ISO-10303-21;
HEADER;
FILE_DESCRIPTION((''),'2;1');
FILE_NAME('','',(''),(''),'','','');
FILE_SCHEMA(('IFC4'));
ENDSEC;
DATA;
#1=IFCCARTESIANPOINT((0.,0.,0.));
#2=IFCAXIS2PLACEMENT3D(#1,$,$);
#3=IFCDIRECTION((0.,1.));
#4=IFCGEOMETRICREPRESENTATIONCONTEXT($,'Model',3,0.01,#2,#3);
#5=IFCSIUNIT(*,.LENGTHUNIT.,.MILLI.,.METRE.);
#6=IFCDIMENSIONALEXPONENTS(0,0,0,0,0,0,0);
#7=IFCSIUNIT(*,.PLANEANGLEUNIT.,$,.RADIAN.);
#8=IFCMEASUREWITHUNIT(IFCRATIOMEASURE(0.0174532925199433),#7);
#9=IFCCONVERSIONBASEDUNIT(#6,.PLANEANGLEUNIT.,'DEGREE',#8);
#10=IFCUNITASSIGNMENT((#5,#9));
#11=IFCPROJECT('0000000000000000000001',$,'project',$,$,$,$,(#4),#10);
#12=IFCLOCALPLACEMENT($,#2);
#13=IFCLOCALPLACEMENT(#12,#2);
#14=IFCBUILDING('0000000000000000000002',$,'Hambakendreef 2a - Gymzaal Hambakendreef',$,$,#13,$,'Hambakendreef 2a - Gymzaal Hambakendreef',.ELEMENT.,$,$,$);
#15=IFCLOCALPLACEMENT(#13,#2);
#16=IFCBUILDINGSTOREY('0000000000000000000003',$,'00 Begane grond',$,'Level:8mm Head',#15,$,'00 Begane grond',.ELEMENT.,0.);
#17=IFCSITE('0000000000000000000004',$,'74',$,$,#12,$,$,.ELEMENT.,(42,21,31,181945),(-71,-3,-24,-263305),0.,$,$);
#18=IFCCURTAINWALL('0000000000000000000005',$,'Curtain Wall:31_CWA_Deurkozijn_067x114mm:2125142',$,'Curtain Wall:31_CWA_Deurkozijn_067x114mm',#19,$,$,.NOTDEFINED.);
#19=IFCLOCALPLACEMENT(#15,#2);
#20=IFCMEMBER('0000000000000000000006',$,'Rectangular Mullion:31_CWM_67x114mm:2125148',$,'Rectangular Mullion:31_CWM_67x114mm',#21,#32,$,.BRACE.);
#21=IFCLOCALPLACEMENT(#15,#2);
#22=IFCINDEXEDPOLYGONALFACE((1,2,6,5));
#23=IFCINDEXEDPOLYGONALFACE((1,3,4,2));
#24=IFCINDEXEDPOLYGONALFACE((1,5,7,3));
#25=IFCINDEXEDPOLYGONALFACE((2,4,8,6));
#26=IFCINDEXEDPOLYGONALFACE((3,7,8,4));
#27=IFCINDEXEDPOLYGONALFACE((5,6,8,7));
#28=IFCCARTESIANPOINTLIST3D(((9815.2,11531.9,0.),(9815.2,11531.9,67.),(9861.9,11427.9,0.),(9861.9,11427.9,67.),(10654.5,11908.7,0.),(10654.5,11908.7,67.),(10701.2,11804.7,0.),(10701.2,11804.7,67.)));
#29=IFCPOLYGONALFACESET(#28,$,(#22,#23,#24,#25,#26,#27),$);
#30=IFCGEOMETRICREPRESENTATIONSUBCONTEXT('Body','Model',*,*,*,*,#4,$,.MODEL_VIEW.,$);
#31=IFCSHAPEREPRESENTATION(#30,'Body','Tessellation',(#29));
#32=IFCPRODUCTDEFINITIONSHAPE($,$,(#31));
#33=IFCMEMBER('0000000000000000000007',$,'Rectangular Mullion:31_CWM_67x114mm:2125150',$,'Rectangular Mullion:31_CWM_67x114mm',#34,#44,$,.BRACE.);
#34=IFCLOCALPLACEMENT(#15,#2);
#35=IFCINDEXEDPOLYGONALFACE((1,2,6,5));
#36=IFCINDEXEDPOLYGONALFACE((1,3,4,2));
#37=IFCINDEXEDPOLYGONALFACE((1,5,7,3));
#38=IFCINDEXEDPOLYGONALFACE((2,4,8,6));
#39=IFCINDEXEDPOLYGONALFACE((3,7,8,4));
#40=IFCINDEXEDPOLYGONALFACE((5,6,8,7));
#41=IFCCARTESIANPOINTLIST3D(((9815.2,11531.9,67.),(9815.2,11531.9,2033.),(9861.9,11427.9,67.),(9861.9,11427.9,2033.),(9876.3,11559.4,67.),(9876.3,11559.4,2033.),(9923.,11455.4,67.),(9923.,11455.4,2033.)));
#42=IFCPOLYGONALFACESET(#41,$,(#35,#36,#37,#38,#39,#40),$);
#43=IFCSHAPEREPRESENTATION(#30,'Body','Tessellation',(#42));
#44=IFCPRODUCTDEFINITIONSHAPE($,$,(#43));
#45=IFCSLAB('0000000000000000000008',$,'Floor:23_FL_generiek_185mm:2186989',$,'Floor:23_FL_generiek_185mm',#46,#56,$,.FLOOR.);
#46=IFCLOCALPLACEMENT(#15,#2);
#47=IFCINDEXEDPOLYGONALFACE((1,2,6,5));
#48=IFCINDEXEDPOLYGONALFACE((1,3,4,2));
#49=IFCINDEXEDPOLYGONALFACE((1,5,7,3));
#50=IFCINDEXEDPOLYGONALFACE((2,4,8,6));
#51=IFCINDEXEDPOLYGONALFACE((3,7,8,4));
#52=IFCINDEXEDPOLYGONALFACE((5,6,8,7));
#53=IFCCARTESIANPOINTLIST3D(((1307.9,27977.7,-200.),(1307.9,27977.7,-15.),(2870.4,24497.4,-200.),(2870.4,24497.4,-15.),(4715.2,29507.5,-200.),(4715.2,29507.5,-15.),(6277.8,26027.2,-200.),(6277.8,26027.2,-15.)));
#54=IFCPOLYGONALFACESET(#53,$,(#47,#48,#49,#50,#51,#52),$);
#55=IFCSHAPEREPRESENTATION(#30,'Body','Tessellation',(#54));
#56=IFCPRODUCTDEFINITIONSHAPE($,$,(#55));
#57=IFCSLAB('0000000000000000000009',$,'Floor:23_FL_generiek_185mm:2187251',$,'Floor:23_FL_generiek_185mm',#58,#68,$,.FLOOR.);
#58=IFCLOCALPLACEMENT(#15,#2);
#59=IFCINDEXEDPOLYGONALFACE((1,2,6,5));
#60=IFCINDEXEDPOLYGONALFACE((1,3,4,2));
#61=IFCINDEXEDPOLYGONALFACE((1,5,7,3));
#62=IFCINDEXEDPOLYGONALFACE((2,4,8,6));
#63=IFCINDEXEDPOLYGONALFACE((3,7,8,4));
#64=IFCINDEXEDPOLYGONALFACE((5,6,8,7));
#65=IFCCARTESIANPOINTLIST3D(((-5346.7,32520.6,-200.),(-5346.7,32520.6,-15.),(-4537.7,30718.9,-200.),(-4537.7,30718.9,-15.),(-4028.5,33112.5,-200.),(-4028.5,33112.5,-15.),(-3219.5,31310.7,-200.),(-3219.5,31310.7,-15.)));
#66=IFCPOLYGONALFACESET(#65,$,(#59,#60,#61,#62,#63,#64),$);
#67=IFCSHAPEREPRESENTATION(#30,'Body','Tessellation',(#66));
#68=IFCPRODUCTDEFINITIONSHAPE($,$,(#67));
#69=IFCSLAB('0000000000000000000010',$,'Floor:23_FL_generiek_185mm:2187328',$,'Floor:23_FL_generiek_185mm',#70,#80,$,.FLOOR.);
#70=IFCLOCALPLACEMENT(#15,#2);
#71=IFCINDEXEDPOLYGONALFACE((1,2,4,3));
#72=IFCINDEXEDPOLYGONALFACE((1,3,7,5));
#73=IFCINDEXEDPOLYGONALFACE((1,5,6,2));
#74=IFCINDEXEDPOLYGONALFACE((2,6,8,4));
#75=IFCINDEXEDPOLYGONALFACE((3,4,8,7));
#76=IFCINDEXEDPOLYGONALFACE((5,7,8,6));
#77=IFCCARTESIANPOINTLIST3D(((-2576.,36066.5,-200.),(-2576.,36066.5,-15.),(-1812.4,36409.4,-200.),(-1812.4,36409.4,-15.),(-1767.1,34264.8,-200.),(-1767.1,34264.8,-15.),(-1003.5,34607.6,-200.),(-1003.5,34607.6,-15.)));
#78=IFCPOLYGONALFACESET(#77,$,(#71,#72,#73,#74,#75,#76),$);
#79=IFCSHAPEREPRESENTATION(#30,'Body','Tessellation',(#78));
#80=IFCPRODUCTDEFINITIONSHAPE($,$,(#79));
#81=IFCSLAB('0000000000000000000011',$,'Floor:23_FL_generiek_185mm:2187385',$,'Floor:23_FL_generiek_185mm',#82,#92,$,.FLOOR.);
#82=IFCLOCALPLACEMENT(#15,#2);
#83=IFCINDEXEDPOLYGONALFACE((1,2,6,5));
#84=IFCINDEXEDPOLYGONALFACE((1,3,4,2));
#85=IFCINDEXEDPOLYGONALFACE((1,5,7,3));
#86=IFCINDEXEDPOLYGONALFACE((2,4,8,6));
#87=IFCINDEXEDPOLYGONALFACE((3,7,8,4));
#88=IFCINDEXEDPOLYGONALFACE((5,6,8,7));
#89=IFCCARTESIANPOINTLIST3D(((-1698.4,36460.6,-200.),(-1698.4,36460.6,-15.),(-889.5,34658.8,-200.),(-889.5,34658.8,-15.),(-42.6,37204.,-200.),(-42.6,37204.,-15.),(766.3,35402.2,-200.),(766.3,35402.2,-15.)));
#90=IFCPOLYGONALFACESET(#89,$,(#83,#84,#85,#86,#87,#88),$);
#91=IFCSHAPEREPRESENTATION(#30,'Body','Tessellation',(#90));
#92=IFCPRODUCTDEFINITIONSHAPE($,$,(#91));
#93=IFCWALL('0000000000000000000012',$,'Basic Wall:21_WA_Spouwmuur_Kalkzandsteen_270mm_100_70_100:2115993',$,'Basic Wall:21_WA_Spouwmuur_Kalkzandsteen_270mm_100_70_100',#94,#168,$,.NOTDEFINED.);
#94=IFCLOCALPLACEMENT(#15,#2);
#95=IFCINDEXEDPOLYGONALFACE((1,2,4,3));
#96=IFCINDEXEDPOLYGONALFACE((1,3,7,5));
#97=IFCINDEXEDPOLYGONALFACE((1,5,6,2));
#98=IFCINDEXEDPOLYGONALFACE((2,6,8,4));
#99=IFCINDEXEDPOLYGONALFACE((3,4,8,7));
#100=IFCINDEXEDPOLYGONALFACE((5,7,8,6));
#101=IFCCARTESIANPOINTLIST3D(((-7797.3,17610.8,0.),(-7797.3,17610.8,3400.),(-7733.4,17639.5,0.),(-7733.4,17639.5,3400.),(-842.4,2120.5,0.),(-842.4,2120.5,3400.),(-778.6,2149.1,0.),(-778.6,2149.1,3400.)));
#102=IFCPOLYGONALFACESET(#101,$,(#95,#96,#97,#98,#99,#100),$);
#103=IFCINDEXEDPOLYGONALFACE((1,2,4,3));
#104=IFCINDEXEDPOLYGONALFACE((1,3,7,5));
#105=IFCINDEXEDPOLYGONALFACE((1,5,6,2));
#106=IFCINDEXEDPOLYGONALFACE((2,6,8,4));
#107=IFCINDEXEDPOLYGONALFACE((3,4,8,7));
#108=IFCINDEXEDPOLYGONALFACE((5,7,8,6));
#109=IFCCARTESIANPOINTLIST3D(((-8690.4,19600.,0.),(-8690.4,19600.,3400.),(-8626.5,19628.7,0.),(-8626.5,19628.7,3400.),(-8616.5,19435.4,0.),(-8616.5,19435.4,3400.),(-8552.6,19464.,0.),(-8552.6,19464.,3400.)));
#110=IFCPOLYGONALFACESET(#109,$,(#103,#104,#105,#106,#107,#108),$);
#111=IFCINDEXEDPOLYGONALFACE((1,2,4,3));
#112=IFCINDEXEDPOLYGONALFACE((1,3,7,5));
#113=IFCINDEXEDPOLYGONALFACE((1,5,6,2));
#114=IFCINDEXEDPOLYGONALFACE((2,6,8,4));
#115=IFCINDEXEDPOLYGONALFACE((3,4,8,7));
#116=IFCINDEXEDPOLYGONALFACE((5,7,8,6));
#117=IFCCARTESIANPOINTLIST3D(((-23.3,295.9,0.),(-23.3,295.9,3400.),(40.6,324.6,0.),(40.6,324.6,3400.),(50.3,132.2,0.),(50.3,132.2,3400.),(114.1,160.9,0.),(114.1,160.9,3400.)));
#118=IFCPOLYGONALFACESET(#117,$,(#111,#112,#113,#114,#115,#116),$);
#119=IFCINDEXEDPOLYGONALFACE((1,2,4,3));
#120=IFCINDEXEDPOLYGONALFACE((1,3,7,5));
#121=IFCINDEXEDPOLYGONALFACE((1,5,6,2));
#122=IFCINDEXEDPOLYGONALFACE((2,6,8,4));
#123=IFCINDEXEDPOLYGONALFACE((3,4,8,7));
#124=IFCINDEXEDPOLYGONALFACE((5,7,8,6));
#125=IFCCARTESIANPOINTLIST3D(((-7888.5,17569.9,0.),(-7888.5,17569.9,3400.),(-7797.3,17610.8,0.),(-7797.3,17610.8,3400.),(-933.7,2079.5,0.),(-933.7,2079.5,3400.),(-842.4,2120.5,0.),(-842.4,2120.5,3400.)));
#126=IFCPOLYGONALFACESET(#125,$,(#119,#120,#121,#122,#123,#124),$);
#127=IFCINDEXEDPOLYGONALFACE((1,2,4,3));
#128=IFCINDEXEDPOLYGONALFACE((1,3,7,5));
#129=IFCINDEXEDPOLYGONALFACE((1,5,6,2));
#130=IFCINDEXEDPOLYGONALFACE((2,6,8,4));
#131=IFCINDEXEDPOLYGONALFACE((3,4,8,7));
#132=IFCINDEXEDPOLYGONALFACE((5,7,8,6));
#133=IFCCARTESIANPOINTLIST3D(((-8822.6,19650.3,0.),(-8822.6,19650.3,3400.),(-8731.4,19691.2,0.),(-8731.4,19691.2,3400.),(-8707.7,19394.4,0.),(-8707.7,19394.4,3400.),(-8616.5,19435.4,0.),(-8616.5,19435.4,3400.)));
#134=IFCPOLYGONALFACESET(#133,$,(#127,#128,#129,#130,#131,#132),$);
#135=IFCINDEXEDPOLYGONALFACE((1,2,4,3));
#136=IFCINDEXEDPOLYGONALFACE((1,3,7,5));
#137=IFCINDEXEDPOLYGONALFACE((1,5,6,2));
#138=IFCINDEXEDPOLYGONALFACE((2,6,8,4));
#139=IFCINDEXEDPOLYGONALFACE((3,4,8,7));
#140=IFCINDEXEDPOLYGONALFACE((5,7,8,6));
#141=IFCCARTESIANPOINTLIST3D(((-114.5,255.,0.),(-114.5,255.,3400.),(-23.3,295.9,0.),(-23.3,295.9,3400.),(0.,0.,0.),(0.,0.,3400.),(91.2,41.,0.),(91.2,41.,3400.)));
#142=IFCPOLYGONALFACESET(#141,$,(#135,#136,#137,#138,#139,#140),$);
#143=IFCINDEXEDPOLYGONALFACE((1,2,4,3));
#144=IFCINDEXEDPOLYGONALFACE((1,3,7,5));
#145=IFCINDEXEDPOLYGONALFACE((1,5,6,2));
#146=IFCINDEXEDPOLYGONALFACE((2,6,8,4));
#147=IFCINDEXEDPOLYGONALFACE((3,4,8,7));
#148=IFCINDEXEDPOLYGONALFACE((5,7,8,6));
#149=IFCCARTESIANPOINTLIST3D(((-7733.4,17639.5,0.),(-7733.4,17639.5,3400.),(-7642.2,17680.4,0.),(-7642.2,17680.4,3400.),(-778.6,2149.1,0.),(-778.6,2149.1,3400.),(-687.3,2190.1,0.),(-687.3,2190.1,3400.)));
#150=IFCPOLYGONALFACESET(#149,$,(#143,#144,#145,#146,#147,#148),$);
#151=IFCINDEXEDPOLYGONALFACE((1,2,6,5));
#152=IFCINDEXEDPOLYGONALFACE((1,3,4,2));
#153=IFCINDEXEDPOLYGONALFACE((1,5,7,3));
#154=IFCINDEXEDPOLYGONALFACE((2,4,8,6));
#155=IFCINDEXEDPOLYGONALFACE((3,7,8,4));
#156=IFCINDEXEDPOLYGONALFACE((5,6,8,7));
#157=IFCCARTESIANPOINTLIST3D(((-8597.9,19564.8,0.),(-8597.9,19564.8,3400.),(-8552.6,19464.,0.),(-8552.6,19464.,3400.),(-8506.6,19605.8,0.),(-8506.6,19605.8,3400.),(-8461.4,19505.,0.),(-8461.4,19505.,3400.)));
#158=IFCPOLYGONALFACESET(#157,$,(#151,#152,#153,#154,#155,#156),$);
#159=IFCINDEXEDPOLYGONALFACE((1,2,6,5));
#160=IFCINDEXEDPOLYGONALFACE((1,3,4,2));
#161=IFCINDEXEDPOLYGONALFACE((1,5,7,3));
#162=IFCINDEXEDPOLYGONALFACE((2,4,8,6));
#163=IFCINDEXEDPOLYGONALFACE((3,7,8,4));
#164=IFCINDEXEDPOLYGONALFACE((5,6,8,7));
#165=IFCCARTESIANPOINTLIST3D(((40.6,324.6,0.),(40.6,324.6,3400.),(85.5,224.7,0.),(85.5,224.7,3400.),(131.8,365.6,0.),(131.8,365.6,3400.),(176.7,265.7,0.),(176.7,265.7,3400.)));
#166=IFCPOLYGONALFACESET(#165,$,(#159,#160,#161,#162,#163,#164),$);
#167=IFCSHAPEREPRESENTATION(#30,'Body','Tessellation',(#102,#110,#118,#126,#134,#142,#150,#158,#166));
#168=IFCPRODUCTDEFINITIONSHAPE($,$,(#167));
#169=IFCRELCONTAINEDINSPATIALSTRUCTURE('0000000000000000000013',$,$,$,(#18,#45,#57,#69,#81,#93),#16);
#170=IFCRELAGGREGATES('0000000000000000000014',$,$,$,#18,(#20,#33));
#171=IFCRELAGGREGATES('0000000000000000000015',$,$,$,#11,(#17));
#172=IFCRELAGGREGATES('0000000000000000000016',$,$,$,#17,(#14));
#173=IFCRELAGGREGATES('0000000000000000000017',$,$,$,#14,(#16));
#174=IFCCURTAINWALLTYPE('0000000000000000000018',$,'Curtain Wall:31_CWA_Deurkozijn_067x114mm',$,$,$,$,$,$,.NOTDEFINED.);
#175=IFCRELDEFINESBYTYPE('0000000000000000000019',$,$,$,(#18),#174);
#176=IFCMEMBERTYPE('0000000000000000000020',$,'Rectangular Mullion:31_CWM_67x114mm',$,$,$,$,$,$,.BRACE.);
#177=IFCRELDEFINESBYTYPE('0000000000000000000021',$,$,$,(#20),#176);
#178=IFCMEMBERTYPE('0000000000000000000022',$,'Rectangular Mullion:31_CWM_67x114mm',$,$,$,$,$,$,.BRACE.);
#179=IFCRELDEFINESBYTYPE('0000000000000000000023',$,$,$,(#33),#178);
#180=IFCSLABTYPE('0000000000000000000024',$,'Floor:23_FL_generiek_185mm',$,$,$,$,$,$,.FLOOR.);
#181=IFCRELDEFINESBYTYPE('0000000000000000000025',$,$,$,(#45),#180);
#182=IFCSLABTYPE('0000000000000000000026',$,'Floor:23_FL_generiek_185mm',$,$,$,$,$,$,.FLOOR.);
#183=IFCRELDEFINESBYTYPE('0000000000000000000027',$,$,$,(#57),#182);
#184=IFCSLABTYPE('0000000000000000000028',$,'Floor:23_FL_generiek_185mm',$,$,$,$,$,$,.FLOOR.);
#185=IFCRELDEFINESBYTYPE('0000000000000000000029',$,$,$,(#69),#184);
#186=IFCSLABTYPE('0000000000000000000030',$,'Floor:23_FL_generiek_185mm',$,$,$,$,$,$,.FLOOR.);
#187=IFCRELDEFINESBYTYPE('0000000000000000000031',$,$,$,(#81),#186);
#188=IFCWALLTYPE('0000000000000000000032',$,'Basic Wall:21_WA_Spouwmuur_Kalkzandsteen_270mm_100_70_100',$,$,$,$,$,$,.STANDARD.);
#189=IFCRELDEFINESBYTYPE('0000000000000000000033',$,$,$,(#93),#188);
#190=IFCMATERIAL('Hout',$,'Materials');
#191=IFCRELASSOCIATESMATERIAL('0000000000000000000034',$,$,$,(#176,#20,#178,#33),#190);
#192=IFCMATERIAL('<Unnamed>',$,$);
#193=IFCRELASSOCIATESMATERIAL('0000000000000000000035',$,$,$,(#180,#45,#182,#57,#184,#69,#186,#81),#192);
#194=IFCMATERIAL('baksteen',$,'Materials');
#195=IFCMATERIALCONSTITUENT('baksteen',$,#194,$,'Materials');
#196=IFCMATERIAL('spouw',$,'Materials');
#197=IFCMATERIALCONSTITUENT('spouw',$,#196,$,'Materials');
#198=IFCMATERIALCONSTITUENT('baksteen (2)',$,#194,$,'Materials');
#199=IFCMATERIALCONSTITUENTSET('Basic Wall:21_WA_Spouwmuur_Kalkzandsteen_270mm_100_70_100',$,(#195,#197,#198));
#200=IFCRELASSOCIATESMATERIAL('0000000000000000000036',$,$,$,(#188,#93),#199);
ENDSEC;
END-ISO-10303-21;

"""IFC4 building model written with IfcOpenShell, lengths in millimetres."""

from ifc_helpers import new_model, entity, si_unit, converted_unit, direction, frame, origin, place, context, subcontext, project, spatial, indexed_curve, outline, extrude, source, transform, mapped, material, constituent, constituent_set, type_object, type_shapes, element, aggregate, save


model = new_model("IFC4")

# Units and contexts
model_context = context("Model", 3, precision=0.01, world=origin(), true_north=direction((0.0, 1.0)))
body_context = subcontext(model_context, "Body", "Model", "MODEL_VIEW")
ifc_project = project(units=[si_unit("LENGTHUNIT", "METRE", prefix="MILLI"), converted_unit("PLANEANGLEUNIT", "DEGREE", entity("IfcRatioMeasure", 0.0174532925199433), si_unit("PLANEANGLEUNIT", "RADIAN"), dimensions=[0, 0, 0, 0, 0, 0, 0])], contexts=[model_context])

# Site, building, storey
site_placement = place(None, origin())
site = spatial("IfcSite", under=ifc_project, at=site_placement, Name="74", CompositionType="ELEMENT", RefLatitude=(42, 21, 31, 181945), RefLongitude=(-71, -3, -24, -263305), RefElevation=0.0)
building_placement = place(site_placement, origin())
building = spatial("IfcBuilding", under=site, at=building_placement, Name="Hambakendreef 2a - Gymzaal Hambakendreef", LongName="Hambakendreef 2a - Gymzaal Hambakendreef", CompositionType="ELEMENT")
storey_placement = place(building_placement, origin())
storey = spatial("IfcBuildingStorey", under=building, at=storey_placement, Name="00 Begane grond", ObjectType="Level:8mm Head", LongName="00 Begane grond", CompositionType="ELEMENT", Elevation=0.0)

# Shared definitions
ifc_material_1 = material(Name="<Unnamed>")

# Curtain wall, members
curtain_wall_type = type_object("IfcCurtainWallType", Name="Curtain Wall:31_CWA_Deurkozijn_067x114mm", PredefinedType="NOTDEFINED")
curtain_wall_placement = place(storey_placement, origin())
curtain_wall = element("IfcCurtainWall", 1, at=curtain_wall_placement, inside=storey, type_object=curtain_wall_type, Name="Curtain Wall:31_CWA_Deurkozijn_067x114mm:2125142", ObjectType="Curtain Wall:31_CWA_Deurkozijn_067x114mm", PredefinedType="NOTDEFINED")
ifc_material_2 = material(Name="Hout", Category="Materials")
member_type_1 = type_object("IfcMemberType", Name="Rectangular Mullion:31_CWM_67x114mm", PredefinedType="BRACE", material=ifc_material_2)
shared_shape_1 = source(origin(), body_context, "Body", "SweptSolid", [
    extrude(outline(indexed_curve([(-57.0, -33.5), (57.0, -33.5), (57.0, 33.5), (-57.0, 33.5), (-57.0, -33.5)], self_intersect=False)), frame((-33.5, 0.0, -920.0), z_axis=(0.0, 0.0, 1.0), x_axis=(0.0, -1.0, 0.0)), (0.0, 0.0, 1.0), 920.0),
])
type_shapes(member_type_1, [shared_shape_1])
member_1_placement = place(storey_placement, frame((9838.6, 11479.9, 0.0), z_axis=(-0.91227, -0.40959, 0.0), x_axis=(0.0, 0.0, -1.0)))
member_1 = element("IfcMember", 2, at=member_1_placement, type_object=member_type_1, material=ifc_material_2, Name="Rectangular Mullion:31_CWM_67x114mm:2125148", ObjectType="Rectangular Mullion:31_CWM_67x114mm", PredefinedType="BRACE", context=body_context, shape_type="MappedRepresentation", body=[
    mapped(shared_shape_1, transform((0.0, 0.0, 0.0), scale=1.0)),
])
member_type_2 = type_object("IfcMemberType", Name="Rectangular Mullion:31_CWM_67x114mm", PredefinedType="BRACE", material=ifc_material_2)
shared_shape_2 = source(origin(), body_context, "Body", "SweptSolid", [
    extrude(outline(indexed_curve([(-57.0, -33.5), (57.0, -33.5), (57.0, 33.5), (-57.0, 33.5), (-57.0, -33.5)], self_intersect=False)), frame((-33.5, 0.0, -1966.0), z_axis=(0.0, 0.0, 1.0), x_axis=(0.0, -1.0, 0.0)), (0.0, 0.0, 1.0), 1966.0),
])
type_shapes(member_type_2, [shared_shape_2])
member_2_placement = place(storey_placement, frame((9838.6, 11479.9, 2033.0), z_axis=(0.0, 0.0, 1.0), x_axis=(-0.91227, -0.40959, 0.0)))
member_2 = element("IfcMember", 3, at=member_2_placement, type_object=member_type_2, material=ifc_material_2, Name="Rectangular Mullion:31_CWM_67x114mm:2125150", ObjectType="Rectangular Mullion:31_CWM_67x114mm", PredefinedType="BRACE", context=body_context, shape_type="MappedRepresentation", body=[
    mapped(shared_shape_2, transform((0.0, 0.0, 0.0), scale=1.0)),
])
aggregate(curtain_wall, [member_1, member_2])

# Slabs
slab_type_1 = type_object("IfcSlabType", Name="Floor:23_FL_generiek_185mm", PredefinedType="FLOOR", material=ifc_material_1)
slab_1_placement = place(storey_placement, origin())
element("IfcSlab", 4, at=slab_1_placement, inside=storey, type_object=slab_type_1, material=ifc_material_1, Name="Floor:23_FL_generiek_185mm:2186989", ObjectType="Floor:23_FL_generiek_185mm", PredefinedType="FLOOR", context=body_context, shape_type="SweptSolid", body=[
    extrude(outline(indexed_curve([(-1907.5, -1867.5), (1907.5, -1867.5), (1907.5, 1867.5), (-1907.5, 1867.5), (-1907.5, -1867.5)], self_intersect=False)), frame((3792.8, 27002.4, -15.0), z_axis=(0.0, 0.0, -1.0), x_axis=(0.40959, -0.91227, 0.0)), (0.0, 0.0, 1.0), 185.0),
])
slab_type_2 = type_object("IfcSlabType", Name="Floor:23_FL_generiek_185mm", PredefinedType="FLOOR", material=ifc_material_1)
slab_2_placement = place(storey_placement, origin())
element("IfcSlab", 5, at=slab_2_placement, inside=storey, type_object=slab_type_2, material=ifc_material_1, Name="Floor:23_FL_generiek_185mm:2187251", ObjectType="Floor:23_FL_generiek_185mm", PredefinedType="FLOOR", context=body_context, shape_type="SweptSolid", body=[
    extrude(outline(indexed_curve([(-987.5, -722.5), (987.5, -722.5), (987.5, 722.5), (-987.5, 722.5), (-987.5, -722.5)], self_intersect=False)), frame((-4283.1, 31915.7, -15.0), z_axis=(0.0, 0.0, -1.0), x_axis=(0.40959, -0.91227, 0.0)), (0.0, 0.0, 1.0), 185.0),
])
slab_type_3 = type_object("IfcSlabType", Name="Floor:23_FL_generiek_185mm", PredefinedType="FLOOR", material=ifc_material_1)
slab_3_placement = place(storey_placement, origin())
element("IfcSlab", 6, at=slab_3_placement, inside=storey, type_object=slab_type_3, material=ifc_material_1, Name="Floor:23_FL_generiek_185mm:2187328", ObjectType="Floor:23_FL_generiek_185mm", PredefinedType="FLOOR", context=body_context, shape_type="SweptSolid", body=[
    extrude(outline(indexed_curve([(-987.5, -418.5), (987.5, -418.5), (987.5, 418.5), (-987.5, 418.5), (-987.5, -418.5)], self_intersect=False)), frame((-1789.7, 35337.1, -15.0), z_axis=(0.0, 0.0, -1.0), x_axis=(0.40959, -0.91227, 0.0)), (0.0, 0.0, 1.0), 185.0),
])
slab_type_4 = type_object("IfcSlabType", Name="Floor:23_FL_generiek_185mm", PredefinedType="FLOOR", material=ifc_material_1)
slab_4_placement = place(storey_placement, origin())
element("IfcSlab", 7, at=slab_4_placement, inside=storey, type_object=slab_type_4, material=ifc_material_1, Name="Floor:23_FL_generiek_185mm:2187385", ObjectType="Floor:23_FL_generiek_185mm", PredefinedType="FLOOR", context=body_context, shape_type="SweptSolid", body=[
    extrude(outline(indexed_curve([(-987.5, -907.5), (987.5, -907.5), (987.5, 907.5), (-987.5, 907.5), (-987.5, -907.5)], self_intersect=False)), frame((-466.0, 35931.4, -15.0), z_axis=(0.0, 0.0, -1.0), x_axis=(0.40959, -0.91227, 0.0)), (0.0, 0.0, 1.0), 185.0),
])

# Wall, openings
ifc_material_3 = material(Name="baksteen", Category="Materials")
ifc_constituent_1 = constituent(ifc_material_3, Name="baksteen", Category="Materials")
ifc_material_4 = material(Name="spouw", Category="Materials")
ifc_constituent_2 = constituent(ifc_material_4, Name="spouw", Category="Materials")
ifc_constituent_3 = constituent(ifc_material_3, Name="baksteen (2)", Category="Materials")
ifc_constituent_set_1 = constituent_set(constituents=[ifc_constituent_1, ifc_constituent_2, ifc_constituent_3], Name="Basic Wall:21_WA_Spouwmuur_Kalkzandsteen_270mm_100_70_100")
wall_type_1 = type_object("IfcWallType", Name="Basic Wall:21_WA_Spouwmuur_Kalkzandsteen_270mm_100_70_100", PredefinedType="STANDARD", material=ifc_constituent_set_1)
wall_1_placement = place(storey_placement, frame((123.2, 55.3, 0.0), z_axis=(0.0, 0.0, 1.0), x_axis=(-0.40959, 0.91227, 0.0)))
wall_1 = element("IfcWall", 8, at=wall_1_placement, inside=storey, type_object=wall_type_1, material=ifc_constituent_set_1, Name="Basic Wall:21_WA_Spouwmuur_Kalkzandsteen_270mm_100_70_100:2115993", ObjectType="Basic Wall:21_WA_Spouwmuur_Kalkzandsteen_270mm_100_70_100", PredefinedType="NOTDEFINED", context=body_context, shape_type="SweptSolid", body=[
    extrude(outline(indexed_curve([(-8490.0, -35.0), (8490.0, -35.0), (8490.0, 35.0), (-8490.0, 35.0), (-8490.0, -35.0)], self_intersect=False)), frame((10769.5, 0.0, 0.0)), (0.0, 0.0, 1.0), 3400.0),
    extrude(outline(indexed_curve([(-90.2, -35.0), (90.2, -35.0), (90.2, 35.0), (-90.2, 35.0), (-90.2, -35.0)], self_intersect=False)), frame((21349.8, 0.0, 0.0), z_axis=(0.0, 0.0, 1.0), x_axis=(-1.0, 0.0, 0.0)), (0.0, 0.0, 1.0), 3400.0),
    extrude(outline(indexed_curve([(-89.7, -35.0), (89.7, -35.0), (89.7, 35.0), (-89.7, 35.0), (-89.7, -35.0)], self_intersect=False)), frame((189.8, 0.0, 0.0)), (0.0, 0.0, 1.0), 3400.0),
    extrude(outline(indexed_curve([(-50.0, -8490.0), (50.0, -8490.0), (50.0, 8490.0), (-50.0, 8490.0), (-50.0, -8490.0)], self_intersect=False)), frame((10769.5, 85.0, 0.0), z_axis=(0.0, 0.0, 1.0), x_axis=(0.0, -1.0, 0.0)), (0.0, 0.0, 1.0), 3400.0),
    extrude(outline(indexed_curve([(-50.0, -140.2), (50.0, -140.2), (50.0, 140.2), (-50.0, 140.3), (-50.0, -140.2)], self_intersect=False)), frame((21399.8, 85.0, 0.0), z_axis=(0.0, 0.0, 1.0), x_axis=(0.0, -1.0, 0.0)), (0.0, 0.0, 1.0), 3400.0),
    extrude(outline(indexed_curve([(-50.0, -139.8), (50.0, -139.8), (50.0, 139.7), (-50.0, 139.8), (-50.0, -139.8)], self_intersect=False)), frame((139.8, 85.0, 0.0), z_axis=(0.0, 0.0, 1.0), x_axis=(0.0, -1.0, 0.0)), (0.0, 0.0, 1.0), 3400.0),
    extrude(outline(indexed_curve([(-50.0, -8490.0), (50.0, -8490.0), (50.0, 8490.0), (-50.0, 8490.0), (-50.0, -8490.0)], self_intersect=False)), frame((10769.5, -85.0, 0.0), z_axis=(0.0, 0.0, 1.0), x_axis=(0.0, 1.0, 0.0)), (0.0, 0.0, 1.0), 3400.0),
    extrude(outline(indexed_curve([(-35.8, -40.0), (64.2, -40.0), (64.2, 60.0), (-46.3, 60.0), (-46.3, -40.0), (-35.8, -40.0)], self_intersect=False)), frame((21305.8, -95.0, 0.0)), (0.0, 0.0, 1.0), 3400.0),
    extrude(outline(indexed_curve([(36.2, -40.0), (45.7, -40.0), (45.7, 60.0), (-63.8, 60.0), (-63.8, -40.0), (36.2, -40.0)], self_intersect=False)), frame((233.8, -95.0, 0.0)), (0.0, 0.0, 1.0), 3400.0),
])
opening_1_placement = place(wall_1_placement, origin())
element("IfcOpeningElement", 9, at=opening_1_placement, cuts=wall_1, PredefinedType="OPENING", context=body_context, shape_type="SweptSolid", body=[
    extrude(outline(indexed_curve([(-1000.0, -1700.0), (1000.0, -1700.0), (1000.0, 1700.0), (-1000.0, 1700.0), (-1000.0, -1700.0)], self_intersect=False)), frame((1279.5, -287.4, 1700.0), z_axis=(0.0, 1.0, 0.0), x_axis=(-1.0, 0.0, 0.0)), (0.0, 0.0, 1.0), 574.8),
])
opening_2_placement = place(wall_1_placement, origin())
element("IfcOpeningElement", 10, at=opening_2_placement, cuts=wall_1, PredefinedType="OPENING", context=body_context, shape_type="SweptSolid", body=[
    extrude(outline(indexed_curve([(-1700.0, -1000.0), (1700.0, -1000.0), (1700.0, 1000.0), (-1700.0, 1000.0), (-1700.0, -1000.0)], self_intersect=False)), frame((20259.5, -287.4, 1700.0), z_axis=(0.0, 1.0, 0.0), x_axis=(0.0, 0.0, 1.0)), (0.0, 0.0, 1.0), 574.8),
])

save(model, "model.ifc")
